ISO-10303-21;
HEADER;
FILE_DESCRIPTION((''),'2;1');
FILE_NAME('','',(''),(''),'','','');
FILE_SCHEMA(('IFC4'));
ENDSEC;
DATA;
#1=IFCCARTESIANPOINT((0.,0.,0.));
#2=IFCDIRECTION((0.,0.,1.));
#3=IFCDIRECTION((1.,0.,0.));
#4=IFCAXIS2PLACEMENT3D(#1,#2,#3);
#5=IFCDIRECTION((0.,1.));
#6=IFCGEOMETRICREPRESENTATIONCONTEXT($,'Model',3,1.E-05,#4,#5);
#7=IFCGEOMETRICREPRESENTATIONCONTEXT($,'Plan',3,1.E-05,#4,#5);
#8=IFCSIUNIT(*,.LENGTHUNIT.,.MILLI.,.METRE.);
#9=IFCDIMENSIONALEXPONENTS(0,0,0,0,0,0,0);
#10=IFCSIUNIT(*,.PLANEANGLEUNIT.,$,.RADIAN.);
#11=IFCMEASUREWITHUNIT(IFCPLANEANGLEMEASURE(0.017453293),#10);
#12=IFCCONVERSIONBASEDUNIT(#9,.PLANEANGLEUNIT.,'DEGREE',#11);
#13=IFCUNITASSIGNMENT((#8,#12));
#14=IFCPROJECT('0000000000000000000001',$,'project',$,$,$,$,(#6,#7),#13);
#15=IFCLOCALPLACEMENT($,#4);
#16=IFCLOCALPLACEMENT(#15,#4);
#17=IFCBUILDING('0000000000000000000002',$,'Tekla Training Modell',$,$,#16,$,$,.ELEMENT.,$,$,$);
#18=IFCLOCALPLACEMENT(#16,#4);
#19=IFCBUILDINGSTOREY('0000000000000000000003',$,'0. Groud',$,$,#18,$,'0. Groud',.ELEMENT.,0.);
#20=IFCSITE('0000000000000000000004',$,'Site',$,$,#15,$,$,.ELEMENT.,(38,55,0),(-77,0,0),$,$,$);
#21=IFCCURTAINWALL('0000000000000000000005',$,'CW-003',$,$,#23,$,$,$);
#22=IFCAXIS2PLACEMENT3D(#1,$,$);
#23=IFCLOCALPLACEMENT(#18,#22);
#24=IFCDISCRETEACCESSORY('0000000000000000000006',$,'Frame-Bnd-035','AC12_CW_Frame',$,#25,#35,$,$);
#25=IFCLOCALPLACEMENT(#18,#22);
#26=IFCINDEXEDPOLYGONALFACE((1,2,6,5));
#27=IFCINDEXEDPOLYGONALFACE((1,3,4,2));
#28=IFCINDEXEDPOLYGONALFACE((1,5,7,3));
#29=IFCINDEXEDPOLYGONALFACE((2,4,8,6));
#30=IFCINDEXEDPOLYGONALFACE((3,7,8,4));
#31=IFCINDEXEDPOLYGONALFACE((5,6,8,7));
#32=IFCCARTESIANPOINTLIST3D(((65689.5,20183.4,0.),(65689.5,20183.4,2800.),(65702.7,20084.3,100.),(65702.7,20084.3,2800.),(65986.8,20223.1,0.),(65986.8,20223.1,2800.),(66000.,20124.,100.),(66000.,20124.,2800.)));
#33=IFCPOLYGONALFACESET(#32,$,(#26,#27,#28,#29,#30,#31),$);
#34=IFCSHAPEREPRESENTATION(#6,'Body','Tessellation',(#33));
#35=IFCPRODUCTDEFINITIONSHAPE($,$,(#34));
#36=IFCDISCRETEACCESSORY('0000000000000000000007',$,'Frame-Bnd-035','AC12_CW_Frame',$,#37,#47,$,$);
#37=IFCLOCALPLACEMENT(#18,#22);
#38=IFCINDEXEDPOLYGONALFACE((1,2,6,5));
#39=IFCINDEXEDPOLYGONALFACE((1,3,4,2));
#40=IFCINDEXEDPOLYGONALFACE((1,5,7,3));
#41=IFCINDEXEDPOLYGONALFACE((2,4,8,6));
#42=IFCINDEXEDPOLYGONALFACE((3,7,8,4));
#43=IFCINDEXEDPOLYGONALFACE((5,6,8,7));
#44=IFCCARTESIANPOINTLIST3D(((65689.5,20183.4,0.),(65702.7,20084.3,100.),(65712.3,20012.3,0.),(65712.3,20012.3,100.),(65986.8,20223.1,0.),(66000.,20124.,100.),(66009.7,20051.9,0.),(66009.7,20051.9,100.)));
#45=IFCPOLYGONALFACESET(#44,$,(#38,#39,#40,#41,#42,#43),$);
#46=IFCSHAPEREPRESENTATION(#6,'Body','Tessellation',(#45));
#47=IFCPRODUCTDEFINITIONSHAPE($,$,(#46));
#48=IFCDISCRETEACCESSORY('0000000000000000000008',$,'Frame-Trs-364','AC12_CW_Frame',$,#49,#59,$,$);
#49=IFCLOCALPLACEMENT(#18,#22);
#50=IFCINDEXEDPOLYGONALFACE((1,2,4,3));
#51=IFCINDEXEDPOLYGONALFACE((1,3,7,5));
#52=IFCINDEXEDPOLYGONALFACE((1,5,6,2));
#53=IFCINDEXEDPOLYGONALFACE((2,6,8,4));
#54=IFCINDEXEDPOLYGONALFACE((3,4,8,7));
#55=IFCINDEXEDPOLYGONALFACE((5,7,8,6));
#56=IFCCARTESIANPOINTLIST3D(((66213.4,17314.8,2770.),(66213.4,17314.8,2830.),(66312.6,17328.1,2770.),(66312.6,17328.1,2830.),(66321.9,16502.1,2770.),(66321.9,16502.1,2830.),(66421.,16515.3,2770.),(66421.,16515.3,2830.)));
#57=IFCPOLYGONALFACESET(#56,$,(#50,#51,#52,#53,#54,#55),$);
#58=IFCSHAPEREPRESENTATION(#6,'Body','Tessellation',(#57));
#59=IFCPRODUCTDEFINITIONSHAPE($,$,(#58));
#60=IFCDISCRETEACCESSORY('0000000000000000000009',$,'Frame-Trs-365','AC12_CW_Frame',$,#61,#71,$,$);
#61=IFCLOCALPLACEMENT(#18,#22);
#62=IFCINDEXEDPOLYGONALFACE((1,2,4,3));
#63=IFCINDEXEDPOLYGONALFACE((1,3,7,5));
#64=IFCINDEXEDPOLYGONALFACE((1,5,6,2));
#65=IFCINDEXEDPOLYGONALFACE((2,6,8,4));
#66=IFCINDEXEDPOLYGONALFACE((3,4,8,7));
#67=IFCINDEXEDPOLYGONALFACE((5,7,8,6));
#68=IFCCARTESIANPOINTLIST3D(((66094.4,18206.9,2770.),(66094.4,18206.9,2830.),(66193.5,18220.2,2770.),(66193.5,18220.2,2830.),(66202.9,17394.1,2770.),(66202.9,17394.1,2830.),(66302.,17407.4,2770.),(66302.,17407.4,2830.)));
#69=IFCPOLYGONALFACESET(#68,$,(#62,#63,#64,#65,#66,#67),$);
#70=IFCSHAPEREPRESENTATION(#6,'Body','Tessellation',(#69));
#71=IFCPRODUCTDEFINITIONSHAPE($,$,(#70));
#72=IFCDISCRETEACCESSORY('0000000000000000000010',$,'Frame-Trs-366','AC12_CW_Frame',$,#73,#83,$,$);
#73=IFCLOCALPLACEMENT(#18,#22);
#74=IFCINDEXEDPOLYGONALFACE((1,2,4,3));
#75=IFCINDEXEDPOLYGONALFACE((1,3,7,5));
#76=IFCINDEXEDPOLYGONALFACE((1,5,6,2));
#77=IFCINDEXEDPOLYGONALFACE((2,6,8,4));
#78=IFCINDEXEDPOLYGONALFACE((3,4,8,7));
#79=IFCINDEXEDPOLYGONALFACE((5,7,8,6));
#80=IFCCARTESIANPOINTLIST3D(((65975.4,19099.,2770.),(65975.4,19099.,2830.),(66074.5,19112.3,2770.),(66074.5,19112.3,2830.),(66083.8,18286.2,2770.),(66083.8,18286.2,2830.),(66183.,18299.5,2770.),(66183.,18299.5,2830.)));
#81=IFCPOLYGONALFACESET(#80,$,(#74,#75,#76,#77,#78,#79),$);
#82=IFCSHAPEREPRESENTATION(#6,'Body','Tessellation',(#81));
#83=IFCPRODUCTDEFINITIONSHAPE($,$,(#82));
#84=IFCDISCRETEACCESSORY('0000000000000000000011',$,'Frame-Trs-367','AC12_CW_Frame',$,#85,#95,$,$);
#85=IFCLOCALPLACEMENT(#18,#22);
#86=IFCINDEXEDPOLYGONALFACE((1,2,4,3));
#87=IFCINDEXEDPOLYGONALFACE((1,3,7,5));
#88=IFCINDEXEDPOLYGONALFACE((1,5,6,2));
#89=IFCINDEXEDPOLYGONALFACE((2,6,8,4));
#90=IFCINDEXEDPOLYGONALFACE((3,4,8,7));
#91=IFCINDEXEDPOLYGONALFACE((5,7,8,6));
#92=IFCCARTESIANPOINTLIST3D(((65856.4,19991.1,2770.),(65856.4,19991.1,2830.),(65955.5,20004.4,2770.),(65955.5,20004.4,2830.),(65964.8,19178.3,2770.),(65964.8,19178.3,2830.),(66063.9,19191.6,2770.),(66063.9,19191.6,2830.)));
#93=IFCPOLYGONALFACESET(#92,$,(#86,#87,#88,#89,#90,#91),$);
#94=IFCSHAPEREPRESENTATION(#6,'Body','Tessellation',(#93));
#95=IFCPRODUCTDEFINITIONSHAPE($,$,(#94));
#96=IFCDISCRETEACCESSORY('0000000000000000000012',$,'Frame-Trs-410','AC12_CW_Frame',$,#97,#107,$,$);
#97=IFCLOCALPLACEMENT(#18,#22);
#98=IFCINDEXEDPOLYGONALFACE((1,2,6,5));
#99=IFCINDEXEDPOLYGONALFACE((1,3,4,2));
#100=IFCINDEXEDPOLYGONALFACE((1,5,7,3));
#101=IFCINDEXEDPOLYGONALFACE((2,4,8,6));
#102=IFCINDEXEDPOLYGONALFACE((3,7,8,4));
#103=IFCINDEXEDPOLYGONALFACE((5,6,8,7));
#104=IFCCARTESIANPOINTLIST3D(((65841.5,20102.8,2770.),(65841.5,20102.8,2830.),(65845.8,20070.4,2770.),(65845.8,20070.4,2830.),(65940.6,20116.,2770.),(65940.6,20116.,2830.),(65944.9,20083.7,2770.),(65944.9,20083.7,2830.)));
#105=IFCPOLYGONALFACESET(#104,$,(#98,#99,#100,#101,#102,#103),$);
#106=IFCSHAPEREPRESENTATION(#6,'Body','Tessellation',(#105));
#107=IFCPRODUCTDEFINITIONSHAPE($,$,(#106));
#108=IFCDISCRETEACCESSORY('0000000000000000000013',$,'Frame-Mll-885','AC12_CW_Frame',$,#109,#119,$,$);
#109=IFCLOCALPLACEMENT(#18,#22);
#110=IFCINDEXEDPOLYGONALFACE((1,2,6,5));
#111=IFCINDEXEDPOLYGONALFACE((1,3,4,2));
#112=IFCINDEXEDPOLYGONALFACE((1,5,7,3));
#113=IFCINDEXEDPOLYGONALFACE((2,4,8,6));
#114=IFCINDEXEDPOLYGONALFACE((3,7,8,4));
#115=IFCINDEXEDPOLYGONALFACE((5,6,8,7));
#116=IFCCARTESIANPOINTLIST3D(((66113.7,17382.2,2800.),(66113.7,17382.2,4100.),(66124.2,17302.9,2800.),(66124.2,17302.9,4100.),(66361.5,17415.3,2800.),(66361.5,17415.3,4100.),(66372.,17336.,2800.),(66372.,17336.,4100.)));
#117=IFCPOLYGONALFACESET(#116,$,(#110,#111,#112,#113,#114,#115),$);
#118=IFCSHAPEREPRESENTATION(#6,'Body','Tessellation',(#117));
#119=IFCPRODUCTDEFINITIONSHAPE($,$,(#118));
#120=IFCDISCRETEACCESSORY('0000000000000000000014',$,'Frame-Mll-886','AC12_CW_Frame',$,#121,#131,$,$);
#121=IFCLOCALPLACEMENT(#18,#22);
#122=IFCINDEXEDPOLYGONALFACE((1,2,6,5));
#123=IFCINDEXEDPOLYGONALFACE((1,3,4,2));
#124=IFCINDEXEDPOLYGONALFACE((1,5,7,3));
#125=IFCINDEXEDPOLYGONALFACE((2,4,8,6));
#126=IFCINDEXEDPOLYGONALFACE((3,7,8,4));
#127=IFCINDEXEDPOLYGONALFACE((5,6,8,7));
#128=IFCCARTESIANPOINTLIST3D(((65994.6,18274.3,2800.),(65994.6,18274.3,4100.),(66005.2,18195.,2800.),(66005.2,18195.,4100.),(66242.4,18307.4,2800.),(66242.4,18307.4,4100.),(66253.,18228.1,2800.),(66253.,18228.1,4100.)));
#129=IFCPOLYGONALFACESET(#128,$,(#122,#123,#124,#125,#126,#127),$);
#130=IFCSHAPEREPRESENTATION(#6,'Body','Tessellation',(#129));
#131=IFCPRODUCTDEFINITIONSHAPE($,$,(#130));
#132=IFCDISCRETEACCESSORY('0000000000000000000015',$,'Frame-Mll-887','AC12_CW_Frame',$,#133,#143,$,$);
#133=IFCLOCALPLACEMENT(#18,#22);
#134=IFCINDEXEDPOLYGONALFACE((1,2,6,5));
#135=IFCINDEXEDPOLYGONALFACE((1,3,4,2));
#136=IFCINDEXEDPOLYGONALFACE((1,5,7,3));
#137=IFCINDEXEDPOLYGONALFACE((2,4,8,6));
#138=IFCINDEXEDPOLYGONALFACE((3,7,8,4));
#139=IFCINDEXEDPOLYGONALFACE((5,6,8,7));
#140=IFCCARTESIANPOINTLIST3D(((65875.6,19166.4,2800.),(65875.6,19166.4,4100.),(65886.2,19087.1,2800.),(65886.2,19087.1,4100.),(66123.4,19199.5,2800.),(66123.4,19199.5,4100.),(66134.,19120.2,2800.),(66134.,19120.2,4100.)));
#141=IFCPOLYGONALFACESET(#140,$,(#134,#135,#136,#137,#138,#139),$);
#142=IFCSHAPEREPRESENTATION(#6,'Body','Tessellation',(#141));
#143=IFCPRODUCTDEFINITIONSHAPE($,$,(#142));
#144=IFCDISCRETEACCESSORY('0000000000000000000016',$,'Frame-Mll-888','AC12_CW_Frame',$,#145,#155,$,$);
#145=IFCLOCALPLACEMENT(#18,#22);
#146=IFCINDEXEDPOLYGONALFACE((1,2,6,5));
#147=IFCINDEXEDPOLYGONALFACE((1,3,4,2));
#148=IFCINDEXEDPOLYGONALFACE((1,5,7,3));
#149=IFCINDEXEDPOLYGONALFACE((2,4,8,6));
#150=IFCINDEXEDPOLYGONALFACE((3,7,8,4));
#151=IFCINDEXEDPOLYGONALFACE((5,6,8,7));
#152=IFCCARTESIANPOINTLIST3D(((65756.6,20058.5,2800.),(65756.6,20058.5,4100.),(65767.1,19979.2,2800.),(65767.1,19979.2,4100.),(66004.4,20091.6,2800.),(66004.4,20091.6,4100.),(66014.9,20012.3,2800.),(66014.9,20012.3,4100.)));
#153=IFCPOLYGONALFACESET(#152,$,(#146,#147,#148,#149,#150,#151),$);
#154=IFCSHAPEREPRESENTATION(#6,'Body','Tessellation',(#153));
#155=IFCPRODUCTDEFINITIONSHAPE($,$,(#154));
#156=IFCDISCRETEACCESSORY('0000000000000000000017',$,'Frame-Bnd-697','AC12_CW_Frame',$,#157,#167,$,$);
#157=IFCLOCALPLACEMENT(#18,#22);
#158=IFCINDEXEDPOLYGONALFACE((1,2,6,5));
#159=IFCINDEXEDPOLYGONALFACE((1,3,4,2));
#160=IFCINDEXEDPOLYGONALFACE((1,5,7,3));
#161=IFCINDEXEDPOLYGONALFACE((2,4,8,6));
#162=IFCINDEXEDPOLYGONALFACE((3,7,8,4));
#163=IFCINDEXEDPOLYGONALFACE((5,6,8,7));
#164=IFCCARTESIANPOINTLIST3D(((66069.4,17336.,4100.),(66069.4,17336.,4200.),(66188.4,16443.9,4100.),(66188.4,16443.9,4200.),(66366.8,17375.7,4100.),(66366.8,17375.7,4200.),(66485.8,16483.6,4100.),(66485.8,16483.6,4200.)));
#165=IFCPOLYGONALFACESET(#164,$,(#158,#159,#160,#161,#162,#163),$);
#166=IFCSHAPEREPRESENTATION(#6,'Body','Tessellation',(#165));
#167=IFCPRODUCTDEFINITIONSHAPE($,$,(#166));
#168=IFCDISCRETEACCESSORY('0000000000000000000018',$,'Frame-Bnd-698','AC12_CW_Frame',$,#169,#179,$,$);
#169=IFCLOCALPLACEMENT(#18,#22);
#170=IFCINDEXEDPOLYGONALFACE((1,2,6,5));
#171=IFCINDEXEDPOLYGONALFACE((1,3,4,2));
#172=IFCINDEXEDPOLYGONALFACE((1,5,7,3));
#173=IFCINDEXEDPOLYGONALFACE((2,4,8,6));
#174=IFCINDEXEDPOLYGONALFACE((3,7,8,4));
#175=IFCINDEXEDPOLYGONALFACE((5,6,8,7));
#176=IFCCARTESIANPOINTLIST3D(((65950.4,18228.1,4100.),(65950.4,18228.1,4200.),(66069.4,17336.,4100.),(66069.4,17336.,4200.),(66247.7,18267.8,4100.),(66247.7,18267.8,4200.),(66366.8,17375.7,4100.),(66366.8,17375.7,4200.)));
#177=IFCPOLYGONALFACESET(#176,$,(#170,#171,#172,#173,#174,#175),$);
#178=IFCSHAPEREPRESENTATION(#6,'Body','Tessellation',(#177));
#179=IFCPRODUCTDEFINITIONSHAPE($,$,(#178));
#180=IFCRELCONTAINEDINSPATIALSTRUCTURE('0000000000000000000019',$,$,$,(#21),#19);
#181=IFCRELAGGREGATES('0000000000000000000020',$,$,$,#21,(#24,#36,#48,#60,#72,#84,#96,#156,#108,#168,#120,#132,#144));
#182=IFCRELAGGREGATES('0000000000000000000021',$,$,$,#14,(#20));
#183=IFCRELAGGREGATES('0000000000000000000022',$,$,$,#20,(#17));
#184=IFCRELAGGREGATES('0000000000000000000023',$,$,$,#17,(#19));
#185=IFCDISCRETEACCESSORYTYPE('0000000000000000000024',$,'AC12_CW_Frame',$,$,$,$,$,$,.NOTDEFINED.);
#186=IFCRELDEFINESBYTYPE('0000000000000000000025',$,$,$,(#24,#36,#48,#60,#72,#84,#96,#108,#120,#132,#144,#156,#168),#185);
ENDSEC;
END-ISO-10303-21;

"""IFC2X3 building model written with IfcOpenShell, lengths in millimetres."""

from ifc_helpers import new_model, entity, si_unit, converted_unit, direction, frame, origin_with_axes, place, context, project, spatial, polyline, outline, extrude, source, transform, mapped, type_object, element, aggregate, save


model = new_model("IFC2X3")

# Units and contexts
model_context = context("Model", 3, precision=1e-05, world=origin_with_axes(), true_north=direction((0.0, 1.0)))
plan_context = context("Plan", 3, precision=1e-05, world=origin_with_axes(), true_north=direction((0.0, 1.0)))
ifc_project = project(units=[si_unit("LENGTHUNIT", "METRE", prefix="MILLI"), converted_unit("PLANEANGLEUNIT", "DEGREE", entity("IfcPlaneAngleMeasure", 0.017453293), si_unit("PLANEANGLEUNIT", "RADIAN"), dimensions=[0, 0, 0, 0, 0, 0, 0])], contexts=[model_context, plan_context])

# Site, building, storey
site_placement = place(None, origin_with_axes())
site = spatial("IfcSite", under=ifc_project, at=site_placement, Name="Site", CompositionType="ELEMENT", RefLatitude=(38, 55, 0), RefLongitude=(-77, 0, 0))
building_placement = place(site_placement, origin_with_axes())
building = spatial("IfcBuilding", under=site, at=building_placement, Name="Tekla Training Modell", CompositionType="ELEMENT")
storey_placement = place(building_placement, origin_with_axes())
storey = spatial("IfcBuildingStorey", under=building, at=storey_placement, Name="0. Groud", LongName="0. Groud", CompositionType="ELEMENT", Elevation=0.0)

# Curtain wall
curtain_wall_placement = place(storey_placement, frame((68221.7, 3095.5, 0.0), z_axis=(0.0, 0.0, 1.0), x_axis=(-0.132257, 0.991216, 0.0)))
curtain_wall = element("IfcCurtainWall", 1, at=curtain_wall_placement, inside=storey, Name="CW-003")

# Discrete accessories
discrete_accessory_type = type_object("IfcDiscreteAccessoryType", Name="AC12_CW_Frame")
shared_shape_1 = source(origin_with_axes(), model_context, "Body", "SweptSolid", [
    extrude(outline(polyline([(0.0, 0.0), (141.4, 0.0), (-1838.5, -1979.9), (-1909.2, -1909.2), (0.0, 0.0)])), origin_with_axes(), (0.0, 0.0, 1.0), 300.0),
])
discrete_accessory_1_placement = place(storey_placement, frame((66000.0, 20124.0, 100.0), z_axis=(-0.991216, -0.132257, 0.0), x_axis=(-0.09352, 0.700895, -0.707107)))
discrete_accessory_1 = element("IfcDiscreteAccessory", 2, at=discrete_accessory_1_placement, type_object=discrete_accessory_type, Name="Frame-Bnd-035", Description="AC12_CW_Frame", context=model_context, shape_type="MappedRepresentation", body=[
    mapped(shared_shape_1, transform((0.0, 0.0, 0.0), scale=1.0)),
])
shared_shape_2 = source(origin_with_axes(), model_context, "Body", "SweptSolid", [
    extrude(outline(polyline([(0.0, 0.0), (100.0, 0.0), (100.0, -172.7), (0.0, -72.7), (0.0, 0.0)])), origin_with_axes(), (0.0, 0.0, 1.0), 300.0),
])
discrete_accessory_2_placement = place(storey_placement, frame((66009.7, 20051.9, 100.0), z_axis=(-0.991216, -0.132257, 0.0), x_axis=(0.0, 0.0, -1.0)))
discrete_accessory_2 = element("IfcDiscreteAccessory", 3, at=discrete_accessory_2_placement, type_object=discrete_accessory_type, Name="Frame-Bnd-035", Description="AC12_CW_Frame", context=model_context, shape_type="MappedRepresentation", body=[
    mapped(shared_shape_2, transform((0.0, 0.0, 0.0), scale=1.0)),
])
shared_shape_3 = source(origin_with_axes(), model_context, "Body", "SweptSolid", [
    extrude(outline(polyline([(0.0, 0.0), (100.0, 0.0), (100.0, -820.0), (0.0, -820.0), (0.0, 0.0)])), origin_with_axes(), (0.0, 0.0, 1.0), 60.0),
])
discrete_accessory_3_placement = place(storey_placement, frame((66321.9, 16502.1, 2830.0), z_axis=(0.0, 0.0, -1.0), x_axis=(0.991216, 0.132257, 0.0)))
discrete_accessory_3 = element("IfcDiscreteAccessory", 4, at=discrete_accessory_3_placement, type_object=discrete_accessory_type, Name="Frame-Trs-364", Description="AC12_CW_Frame", context=model_context, shape_type="MappedRepresentation", body=[
    mapped(shared_shape_3, transform((0.0, 0.0, 0.0), scale=1.0)),
])
discrete_accessory_4_placement = place(storey_placement, frame((66202.9, 17394.1, 2830.0), z_axis=(0.0, 0.0, -1.0), x_axis=(0.991216, 0.132257, 0.0)))
discrete_accessory_4 = element("IfcDiscreteAccessory", 5, at=discrete_accessory_4_placement, type_object=discrete_accessory_type, Name="Frame-Trs-365", Description="AC12_CW_Frame", context=model_context, shape_type="MappedRepresentation", body=[
    mapped(shared_shape_3, transform((0.0, 0.0, 0.0), scale=1.0)),
])
discrete_accessory_5_placement = place(storey_placement, frame((66083.8, 18286.2, 2830.0), z_axis=(0.0, 0.0, -1.0), x_axis=(0.991216, 0.132257, 0.0)))
discrete_accessory_5 = element("IfcDiscreteAccessory", 6, at=discrete_accessory_5_placement, type_object=discrete_accessory_type, Name="Frame-Trs-366", Description="AC12_CW_Frame", context=model_context, shape_type="MappedRepresentation", body=[
    mapped(shared_shape_3, transform((0.0, 0.0, 0.0), scale=1.0)),
])
discrete_accessory_6_placement = place(storey_placement, frame((65964.8, 19178.3, 2830.0), z_axis=(0.0, 0.0, -1.0), x_axis=(0.991216, 0.132257, 0.0)))
discrete_accessory_6 = element("IfcDiscreteAccessory", 7, at=discrete_accessory_6_placement, type_object=discrete_accessory_type, Name="Frame-Trs-367", Description="AC12_CW_Frame", context=model_context, shape_type="MappedRepresentation", body=[
    mapped(shared_shape_3, transform((0.0, 0.0, 0.0), scale=1.0)),
])
shared_shape_4 = source(origin_with_axes(), model_context, "Body", "SweptSolid", [
    extrude(outline(polyline([(0.0, 0.0), (100.0, 0.0), (100.0, -32.7), (0.0, -32.7), (0.0, 0.0)])), origin_with_axes(), (0.0, 0.0, 1.0), 60.0),
])
discrete_accessory_7_placement = place(storey_placement, frame((65845.8, 20070.4, 2830.0), z_axis=(0.0, 0.0, -1.0), x_axis=(0.991216, 0.132257, 0.0)))
discrete_accessory_7 = element("IfcDiscreteAccessory", 8, at=discrete_accessory_7_placement, type_object=discrete_accessory_type, Name="Frame-Trs-410", Description="AC12_CW_Frame", context=model_context, shape_type="MappedRepresentation", body=[
    mapped(shared_shape_4, transform((0.0, 0.0, 0.0), scale=1.0)),
])
shared_shape_5 = source(origin_with_axes(), model_context, "Body", "SweptSolid", [
    extrude(outline(polyline([(0.0, 0.0), (250.0, 0.0), (250.0, -1300.0), (0.0, -1300.0), (0.0, 0.0)])), origin_with_axes(), (0.0, 0.0, 1.0), 80.0),
])
discrete_accessory_8_placement = place(storey_placement, frame((66124.2, 17302.9, 2800.0), z_axis=(-0.132257, 0.991216, 0.0), x_axis=(0.991216, 0.132257, 0.0)))
discrete_accessory_8 = element("IfcDiscreteAccessory", 9, at=discrete_accessory_8_placement, type_object=discrete_accessory_type, Name="Frame-Mll-885", Description="AC12_CW_Frame", context=model_context, shape_type="MappedRepresentation", body=[
    mapped(shared_shape_5, transform((0.0, 0.0, 0.0), scale=1.0)),
])
discrete_accessory_9_placement = place(storey_placement, frame((66005.2, 18195.0, 2800.0), z_axis=(-0.132257, 0.991216, 0.0), x_axis=(0.991216, 0.132257, 0.0)))
discrete_accessory_9 = element("IfcDiscreteAccessory", 10, at=discrete_accessory_9_placement, type_object=discrete_accessory_type, Name="Frame-Mll-886", Description="AC12_CW_Frame", context=model_context, shape_type="MappedRepresentation", body=[
    mapped(shared_shape_5, transform((0.0, 0.0, 0.0), scale=1.0)),
])
discrete_accessory_10_placement = place(storey_placement, frame((65886.2, 19087.1, 2800.0), z_axis=(-0.132257, 0.991216, 0.0), x_axis=(0.991216, 0.132257, 0.0)))
discrete_accessory_10 = element("IfcDiscreteAccessory", 11, at=discrete_accessory_10_placement, type_object=discrete_accessory_type, Name="Frame-Mll-887", Description="AC12_CW_Frame", context=model_context, shape_type="MappedRepresentation", body=[
    mapped(shared_shape_5, transform((0.0, 0.0, 0.0), scale=1.0)),
])
discrete_accessory_11_placement = place(storey_placement, frame((65767.1, 19979.2, 2800.0), z_axis=(-0.132257, 0.991216, 0.0), x_axis=(0.991216, 0.132257, 0.0)))
discrete_accessory_11 = element("IfcDiscreteAccessory", 12, at=discrete_accessory_11_placement, type_object=discrete_accessory_type, Name="Frame-Mll-888", Description="AC12_CW_Frame", context=model_context, shape_type="MappedRepresentation", body=[
    mapped(shared_shape_5, transform((0.0, 0.0, 0.0), scale=1.0)),
])
shared_shape_6 = source(origin_with_axes(), model_context, "Body", "SweptSolid", [
    extrude(outline(polyline([(0.0, 0.0), (300.0, 0.0), (300.0, -900.0), (0.0, -900.0), (0.0, 0.0)])), origin_with_axes(), (0.0, 0.0, 1.0), 100.0),
])
discrete_accessory_12_placement = place(storey_placement, frame((66069.4, 17336.0, 4100.0), z_axis=(0.0, 0.0, 1.0), x_axis=(0.991216, 0.132257, 0.0)))
discrete_accessory_12 = element("IfcDiscreteAccessory", 13, at=discrete_accessory_12_placement, type_object=discrete_accessory_type, Name="Frame-Bnd-697", Description="AC12_CW_Frame", context=model_context, shape_type="MappedRepresentation", body=[
    mapped(shared_shape_6, transform((0.0, 0.0, 0.0), scale=1.0)),
])
discrete_accessory_13_placement = place(storey_placement, frame((65950.4, 18228.1, 4100.0), z_axis=(0.0, 0.0, 1.0), x_axis=(0.991216, 0.132257, 0.0)))
discrete_accessory_13 = element("IfcDiscreteAccessory", 14, at=discrete_accessory_13_placement, type_object=discrete_accessory_type, Name="Frame-Bnd-698", Description="AC12_CW_Frame", context=model_context, shape_type="MappedRepresentation", body=[
    mapped(shared_shape_6, transform((0.0, 0.0, 0.0), scale=1.0)),
])
aggregate(curtain_wall, [discrete_accessory_1, discrete_accessory_2, discrete_accessory_3, discrete_accessory_4, discrete_accessory_5, discrete_accessory_6, discrete_accessory_7, discrete_accessory_12, discrete_accessory_8, discrete_accessory_13, discrete_accessory_9, discrete_accessory_10, discrete_accessory_11])

save(model, "model.ifc")
